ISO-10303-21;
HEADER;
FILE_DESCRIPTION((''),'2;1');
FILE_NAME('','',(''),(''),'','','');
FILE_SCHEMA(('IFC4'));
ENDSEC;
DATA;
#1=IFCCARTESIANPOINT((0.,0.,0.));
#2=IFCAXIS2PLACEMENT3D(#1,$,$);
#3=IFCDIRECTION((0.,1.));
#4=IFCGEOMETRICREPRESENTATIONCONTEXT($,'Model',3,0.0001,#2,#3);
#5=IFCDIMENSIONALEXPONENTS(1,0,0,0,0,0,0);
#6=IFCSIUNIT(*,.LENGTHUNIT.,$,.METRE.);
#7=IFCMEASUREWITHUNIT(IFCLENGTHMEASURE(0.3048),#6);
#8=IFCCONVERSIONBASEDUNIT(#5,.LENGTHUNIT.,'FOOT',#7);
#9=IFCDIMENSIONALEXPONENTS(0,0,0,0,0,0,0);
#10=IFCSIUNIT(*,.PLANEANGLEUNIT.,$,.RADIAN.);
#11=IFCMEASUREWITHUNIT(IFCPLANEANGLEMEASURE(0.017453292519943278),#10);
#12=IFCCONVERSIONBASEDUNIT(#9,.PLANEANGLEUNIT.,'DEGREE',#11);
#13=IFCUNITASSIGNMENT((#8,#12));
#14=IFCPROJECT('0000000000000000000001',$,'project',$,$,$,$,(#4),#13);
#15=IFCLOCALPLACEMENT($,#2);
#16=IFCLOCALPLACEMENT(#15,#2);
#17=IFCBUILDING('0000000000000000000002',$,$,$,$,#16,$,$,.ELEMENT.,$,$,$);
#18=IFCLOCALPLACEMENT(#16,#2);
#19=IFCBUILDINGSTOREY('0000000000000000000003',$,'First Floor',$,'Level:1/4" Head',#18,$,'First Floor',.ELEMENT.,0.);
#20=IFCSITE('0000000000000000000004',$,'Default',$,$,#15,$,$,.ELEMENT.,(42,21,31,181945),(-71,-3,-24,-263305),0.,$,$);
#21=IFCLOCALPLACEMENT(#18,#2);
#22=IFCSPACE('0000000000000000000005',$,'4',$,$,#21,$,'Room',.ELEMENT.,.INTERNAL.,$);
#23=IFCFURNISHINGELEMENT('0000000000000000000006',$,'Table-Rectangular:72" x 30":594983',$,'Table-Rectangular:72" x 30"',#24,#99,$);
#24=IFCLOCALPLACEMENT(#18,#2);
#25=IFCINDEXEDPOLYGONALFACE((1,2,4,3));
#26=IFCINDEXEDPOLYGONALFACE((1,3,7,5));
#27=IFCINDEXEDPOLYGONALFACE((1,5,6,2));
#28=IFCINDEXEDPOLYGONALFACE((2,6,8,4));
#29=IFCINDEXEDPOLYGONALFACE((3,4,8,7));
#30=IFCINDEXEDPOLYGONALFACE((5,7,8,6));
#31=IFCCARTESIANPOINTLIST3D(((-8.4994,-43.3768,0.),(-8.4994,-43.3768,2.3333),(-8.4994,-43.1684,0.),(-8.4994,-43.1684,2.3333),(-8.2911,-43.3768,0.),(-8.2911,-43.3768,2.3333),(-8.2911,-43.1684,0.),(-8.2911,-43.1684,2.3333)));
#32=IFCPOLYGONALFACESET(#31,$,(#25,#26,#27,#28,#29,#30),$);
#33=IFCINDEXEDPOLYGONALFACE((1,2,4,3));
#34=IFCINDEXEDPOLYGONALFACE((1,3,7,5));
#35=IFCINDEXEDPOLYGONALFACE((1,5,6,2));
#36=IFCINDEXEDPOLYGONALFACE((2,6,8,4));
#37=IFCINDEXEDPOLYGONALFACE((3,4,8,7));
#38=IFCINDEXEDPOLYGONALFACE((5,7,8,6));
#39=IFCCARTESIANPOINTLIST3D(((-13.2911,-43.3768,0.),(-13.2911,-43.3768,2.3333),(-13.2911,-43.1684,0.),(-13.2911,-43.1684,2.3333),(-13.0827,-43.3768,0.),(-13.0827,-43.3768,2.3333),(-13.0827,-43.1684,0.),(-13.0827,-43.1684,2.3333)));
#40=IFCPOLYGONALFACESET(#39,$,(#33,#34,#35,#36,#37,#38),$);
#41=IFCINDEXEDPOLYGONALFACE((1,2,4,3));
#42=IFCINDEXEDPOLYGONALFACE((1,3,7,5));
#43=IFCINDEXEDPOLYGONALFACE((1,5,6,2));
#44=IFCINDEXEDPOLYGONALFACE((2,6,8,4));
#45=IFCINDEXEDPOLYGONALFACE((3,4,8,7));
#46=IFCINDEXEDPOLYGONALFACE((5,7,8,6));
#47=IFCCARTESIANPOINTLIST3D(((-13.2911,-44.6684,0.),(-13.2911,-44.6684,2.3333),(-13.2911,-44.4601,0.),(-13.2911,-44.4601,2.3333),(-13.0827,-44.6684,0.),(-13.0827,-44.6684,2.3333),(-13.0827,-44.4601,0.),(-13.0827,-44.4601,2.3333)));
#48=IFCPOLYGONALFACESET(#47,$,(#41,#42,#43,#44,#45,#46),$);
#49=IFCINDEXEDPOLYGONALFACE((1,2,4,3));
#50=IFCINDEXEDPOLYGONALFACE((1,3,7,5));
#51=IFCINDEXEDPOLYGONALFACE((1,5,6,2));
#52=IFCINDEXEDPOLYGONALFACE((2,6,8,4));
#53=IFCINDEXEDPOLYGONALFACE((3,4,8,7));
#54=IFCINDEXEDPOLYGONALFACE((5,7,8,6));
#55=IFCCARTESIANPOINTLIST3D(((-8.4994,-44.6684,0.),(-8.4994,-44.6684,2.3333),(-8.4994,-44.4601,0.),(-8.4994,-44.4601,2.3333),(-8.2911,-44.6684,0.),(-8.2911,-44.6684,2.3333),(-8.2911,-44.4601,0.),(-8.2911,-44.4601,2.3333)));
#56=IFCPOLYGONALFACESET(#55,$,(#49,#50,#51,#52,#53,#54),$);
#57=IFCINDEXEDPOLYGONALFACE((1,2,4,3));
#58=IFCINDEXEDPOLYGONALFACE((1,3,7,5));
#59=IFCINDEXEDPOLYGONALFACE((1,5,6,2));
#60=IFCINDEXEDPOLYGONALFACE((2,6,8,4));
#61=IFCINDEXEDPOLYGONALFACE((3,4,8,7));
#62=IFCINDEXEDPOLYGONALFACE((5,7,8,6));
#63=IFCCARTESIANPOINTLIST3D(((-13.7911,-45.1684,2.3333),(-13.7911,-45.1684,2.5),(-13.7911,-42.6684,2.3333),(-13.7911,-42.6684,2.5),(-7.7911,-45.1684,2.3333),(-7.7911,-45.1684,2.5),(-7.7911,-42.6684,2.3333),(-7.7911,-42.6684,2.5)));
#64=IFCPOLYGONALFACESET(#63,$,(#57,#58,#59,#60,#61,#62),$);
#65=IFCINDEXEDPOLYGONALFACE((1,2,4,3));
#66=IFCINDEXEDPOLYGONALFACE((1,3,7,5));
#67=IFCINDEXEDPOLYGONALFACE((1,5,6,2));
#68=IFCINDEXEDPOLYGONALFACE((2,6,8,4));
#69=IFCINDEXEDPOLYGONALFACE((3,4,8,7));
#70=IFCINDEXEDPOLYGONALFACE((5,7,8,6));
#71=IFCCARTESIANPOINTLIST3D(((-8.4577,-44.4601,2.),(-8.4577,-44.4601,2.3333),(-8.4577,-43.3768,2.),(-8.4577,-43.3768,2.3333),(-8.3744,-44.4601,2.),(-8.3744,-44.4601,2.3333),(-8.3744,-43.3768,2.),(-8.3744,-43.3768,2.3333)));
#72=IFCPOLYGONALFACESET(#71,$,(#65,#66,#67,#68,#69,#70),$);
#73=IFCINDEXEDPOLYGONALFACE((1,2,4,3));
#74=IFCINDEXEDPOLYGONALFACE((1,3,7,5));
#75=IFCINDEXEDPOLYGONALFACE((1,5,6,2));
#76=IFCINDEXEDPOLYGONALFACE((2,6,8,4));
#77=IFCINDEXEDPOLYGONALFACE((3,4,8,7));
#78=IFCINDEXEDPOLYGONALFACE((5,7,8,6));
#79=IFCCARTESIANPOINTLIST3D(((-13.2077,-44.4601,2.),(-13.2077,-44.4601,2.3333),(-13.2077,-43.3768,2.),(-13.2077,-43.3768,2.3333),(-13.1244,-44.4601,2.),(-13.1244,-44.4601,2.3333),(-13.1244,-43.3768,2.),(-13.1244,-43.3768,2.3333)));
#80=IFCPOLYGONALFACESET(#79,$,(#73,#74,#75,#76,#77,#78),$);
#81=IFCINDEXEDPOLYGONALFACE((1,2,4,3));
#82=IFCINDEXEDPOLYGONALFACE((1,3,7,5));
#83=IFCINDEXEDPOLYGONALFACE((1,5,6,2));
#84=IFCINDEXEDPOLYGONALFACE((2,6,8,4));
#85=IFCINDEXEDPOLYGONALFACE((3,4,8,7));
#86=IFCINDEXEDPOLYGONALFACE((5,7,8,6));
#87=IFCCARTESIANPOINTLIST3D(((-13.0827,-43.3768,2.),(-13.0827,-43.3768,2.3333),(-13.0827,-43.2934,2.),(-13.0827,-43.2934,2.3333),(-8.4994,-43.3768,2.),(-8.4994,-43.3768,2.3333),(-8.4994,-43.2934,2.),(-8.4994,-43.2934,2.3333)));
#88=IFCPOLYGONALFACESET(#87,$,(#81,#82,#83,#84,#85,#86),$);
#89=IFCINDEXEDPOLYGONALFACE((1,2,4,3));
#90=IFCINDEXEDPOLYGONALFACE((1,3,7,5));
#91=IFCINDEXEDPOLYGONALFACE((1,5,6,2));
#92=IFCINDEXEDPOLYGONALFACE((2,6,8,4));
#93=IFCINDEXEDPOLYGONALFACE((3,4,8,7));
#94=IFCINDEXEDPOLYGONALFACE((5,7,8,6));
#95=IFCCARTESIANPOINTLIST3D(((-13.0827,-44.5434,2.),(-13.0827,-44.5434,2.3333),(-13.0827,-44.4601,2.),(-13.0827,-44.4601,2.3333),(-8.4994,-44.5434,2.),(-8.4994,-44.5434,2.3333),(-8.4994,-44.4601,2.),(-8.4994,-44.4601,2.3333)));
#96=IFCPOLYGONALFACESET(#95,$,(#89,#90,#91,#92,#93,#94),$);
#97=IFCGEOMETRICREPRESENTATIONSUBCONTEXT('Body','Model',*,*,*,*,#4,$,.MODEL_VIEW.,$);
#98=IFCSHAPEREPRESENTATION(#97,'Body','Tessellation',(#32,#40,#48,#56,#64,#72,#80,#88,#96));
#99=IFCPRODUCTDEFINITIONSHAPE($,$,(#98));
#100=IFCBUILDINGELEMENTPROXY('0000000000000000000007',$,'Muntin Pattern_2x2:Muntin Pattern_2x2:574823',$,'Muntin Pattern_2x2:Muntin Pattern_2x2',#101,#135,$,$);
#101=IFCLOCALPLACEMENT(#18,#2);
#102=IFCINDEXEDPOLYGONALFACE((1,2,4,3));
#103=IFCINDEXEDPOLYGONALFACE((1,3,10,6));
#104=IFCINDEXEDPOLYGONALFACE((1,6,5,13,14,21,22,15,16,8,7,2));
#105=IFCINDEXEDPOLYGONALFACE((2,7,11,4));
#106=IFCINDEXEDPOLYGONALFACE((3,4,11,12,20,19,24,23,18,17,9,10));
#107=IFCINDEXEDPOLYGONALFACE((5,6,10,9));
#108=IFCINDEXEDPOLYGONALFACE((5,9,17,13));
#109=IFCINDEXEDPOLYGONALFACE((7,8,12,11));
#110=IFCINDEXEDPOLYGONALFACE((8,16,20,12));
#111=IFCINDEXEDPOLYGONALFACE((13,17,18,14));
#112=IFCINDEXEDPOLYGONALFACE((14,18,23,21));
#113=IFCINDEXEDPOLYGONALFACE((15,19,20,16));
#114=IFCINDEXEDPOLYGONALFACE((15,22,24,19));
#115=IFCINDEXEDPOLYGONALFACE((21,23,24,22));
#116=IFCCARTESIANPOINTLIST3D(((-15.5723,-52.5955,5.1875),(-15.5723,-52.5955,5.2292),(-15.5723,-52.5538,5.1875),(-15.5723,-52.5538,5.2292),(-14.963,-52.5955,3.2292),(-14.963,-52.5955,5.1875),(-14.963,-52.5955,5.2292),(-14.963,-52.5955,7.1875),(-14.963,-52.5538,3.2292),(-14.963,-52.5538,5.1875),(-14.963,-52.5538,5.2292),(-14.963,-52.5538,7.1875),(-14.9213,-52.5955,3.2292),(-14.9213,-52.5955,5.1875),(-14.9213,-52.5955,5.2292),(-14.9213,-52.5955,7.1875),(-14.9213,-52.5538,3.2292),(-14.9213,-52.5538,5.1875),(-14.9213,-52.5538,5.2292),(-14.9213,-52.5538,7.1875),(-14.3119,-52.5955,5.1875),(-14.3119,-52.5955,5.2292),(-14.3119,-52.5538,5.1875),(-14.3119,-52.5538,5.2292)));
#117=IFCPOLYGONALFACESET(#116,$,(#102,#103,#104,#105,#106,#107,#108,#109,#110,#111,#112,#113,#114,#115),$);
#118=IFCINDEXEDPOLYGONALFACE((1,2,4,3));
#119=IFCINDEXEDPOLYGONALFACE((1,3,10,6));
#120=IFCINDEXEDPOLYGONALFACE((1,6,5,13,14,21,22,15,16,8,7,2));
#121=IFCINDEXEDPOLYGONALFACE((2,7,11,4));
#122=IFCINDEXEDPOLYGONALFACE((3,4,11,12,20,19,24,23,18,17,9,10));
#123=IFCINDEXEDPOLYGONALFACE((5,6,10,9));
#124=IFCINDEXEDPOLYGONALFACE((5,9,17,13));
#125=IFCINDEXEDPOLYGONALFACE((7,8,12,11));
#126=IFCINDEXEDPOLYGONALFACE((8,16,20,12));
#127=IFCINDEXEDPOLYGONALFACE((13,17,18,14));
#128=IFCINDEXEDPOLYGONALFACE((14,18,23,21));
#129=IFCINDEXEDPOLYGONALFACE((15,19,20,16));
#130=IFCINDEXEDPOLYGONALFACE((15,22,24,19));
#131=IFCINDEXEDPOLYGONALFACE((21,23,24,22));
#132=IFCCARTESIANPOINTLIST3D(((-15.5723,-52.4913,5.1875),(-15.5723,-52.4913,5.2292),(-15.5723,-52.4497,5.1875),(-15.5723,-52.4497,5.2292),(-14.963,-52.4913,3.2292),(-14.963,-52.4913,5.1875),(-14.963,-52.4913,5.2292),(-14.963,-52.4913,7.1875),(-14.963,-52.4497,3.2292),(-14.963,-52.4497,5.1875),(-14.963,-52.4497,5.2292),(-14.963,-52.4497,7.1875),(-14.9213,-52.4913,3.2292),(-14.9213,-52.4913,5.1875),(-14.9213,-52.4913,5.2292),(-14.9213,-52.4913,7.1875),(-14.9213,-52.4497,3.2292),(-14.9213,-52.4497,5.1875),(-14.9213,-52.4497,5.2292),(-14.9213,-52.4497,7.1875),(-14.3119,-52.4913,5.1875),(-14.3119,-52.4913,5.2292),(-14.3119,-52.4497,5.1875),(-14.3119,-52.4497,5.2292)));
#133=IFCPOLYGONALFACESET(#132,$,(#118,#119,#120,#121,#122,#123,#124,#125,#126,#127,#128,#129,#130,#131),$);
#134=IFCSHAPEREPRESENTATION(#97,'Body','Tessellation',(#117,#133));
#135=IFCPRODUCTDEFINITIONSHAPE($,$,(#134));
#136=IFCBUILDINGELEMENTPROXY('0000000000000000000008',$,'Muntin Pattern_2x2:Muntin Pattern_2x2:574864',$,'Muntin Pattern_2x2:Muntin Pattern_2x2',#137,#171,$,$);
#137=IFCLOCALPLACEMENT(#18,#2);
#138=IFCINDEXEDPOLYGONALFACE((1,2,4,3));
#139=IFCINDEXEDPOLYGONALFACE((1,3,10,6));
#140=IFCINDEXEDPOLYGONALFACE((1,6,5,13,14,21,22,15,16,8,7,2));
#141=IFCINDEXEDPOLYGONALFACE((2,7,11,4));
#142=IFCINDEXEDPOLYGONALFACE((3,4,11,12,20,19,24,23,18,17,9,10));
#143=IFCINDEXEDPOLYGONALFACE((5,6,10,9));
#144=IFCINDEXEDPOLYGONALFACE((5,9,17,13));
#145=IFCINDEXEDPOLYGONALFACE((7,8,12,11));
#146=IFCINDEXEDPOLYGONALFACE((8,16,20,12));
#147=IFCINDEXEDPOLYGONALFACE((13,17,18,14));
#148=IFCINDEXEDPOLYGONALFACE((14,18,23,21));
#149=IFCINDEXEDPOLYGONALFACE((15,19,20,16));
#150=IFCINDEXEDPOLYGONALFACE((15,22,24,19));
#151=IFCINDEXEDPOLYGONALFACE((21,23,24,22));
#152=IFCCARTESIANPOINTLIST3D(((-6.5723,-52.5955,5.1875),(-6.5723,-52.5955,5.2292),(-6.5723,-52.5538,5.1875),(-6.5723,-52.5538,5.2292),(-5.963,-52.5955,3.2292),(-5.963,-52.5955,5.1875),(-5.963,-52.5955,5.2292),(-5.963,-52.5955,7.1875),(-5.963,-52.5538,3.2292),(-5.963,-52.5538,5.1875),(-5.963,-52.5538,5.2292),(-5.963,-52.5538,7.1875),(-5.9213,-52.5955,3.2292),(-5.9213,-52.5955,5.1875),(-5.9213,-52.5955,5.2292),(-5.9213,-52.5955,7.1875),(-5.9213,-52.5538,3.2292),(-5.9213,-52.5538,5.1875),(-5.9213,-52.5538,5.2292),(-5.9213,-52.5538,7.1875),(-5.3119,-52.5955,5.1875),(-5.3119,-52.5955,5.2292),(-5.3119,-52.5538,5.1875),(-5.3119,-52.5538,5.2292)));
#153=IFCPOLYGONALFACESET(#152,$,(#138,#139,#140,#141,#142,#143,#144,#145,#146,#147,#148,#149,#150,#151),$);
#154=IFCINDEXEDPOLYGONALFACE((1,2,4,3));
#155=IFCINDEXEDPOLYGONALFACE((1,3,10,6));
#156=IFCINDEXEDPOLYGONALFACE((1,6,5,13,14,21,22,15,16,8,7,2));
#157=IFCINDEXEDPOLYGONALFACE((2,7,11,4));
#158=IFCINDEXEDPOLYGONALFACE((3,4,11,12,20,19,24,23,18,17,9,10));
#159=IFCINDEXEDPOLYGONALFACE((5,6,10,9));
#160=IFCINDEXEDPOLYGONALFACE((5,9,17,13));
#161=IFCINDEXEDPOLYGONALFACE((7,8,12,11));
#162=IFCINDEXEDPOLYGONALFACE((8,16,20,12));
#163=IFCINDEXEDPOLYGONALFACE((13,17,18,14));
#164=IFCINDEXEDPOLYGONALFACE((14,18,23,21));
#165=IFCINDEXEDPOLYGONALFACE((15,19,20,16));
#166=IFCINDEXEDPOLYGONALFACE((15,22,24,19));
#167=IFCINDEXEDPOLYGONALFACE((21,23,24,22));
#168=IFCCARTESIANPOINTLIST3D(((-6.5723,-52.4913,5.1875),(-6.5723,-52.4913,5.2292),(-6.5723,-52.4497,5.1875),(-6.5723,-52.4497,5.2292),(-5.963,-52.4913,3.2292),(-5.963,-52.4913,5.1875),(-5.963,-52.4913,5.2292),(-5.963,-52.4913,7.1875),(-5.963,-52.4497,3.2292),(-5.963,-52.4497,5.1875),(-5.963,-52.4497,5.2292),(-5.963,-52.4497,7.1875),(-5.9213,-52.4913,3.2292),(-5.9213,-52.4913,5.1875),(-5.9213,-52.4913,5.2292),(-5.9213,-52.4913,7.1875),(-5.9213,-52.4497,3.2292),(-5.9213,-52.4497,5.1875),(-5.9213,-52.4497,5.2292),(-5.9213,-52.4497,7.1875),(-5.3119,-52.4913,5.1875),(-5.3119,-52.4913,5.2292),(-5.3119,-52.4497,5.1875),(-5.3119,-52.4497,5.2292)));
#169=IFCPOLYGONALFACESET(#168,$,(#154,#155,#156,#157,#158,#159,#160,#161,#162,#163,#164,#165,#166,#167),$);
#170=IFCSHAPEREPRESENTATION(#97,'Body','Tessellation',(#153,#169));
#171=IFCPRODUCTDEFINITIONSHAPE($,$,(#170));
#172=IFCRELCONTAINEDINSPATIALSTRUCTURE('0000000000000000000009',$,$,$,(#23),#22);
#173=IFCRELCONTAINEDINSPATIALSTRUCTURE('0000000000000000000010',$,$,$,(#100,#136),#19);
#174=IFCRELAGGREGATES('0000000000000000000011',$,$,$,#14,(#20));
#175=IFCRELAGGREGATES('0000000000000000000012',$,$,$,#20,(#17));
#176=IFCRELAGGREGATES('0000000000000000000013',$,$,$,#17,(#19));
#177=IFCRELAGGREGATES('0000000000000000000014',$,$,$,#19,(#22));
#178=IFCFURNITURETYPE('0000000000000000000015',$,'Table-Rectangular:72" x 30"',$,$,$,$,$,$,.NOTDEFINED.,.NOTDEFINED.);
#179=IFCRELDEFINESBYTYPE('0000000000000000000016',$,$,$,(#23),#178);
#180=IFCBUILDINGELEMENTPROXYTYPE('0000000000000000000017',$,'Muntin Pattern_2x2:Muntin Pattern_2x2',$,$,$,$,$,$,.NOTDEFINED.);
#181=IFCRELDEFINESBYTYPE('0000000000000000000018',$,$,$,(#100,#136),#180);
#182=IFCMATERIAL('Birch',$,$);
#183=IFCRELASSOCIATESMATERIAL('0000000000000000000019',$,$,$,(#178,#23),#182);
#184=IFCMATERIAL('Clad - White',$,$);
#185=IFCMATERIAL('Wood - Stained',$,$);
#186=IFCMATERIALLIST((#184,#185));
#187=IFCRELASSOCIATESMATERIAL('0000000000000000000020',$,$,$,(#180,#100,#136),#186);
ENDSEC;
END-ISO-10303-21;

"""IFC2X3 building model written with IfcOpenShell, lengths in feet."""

from ifc_helpers import new_model, entity, si_unit, converted_unit, direction, frame, frame_2d, origin, origin_2d_with_axis, place, context, subcontext, project, spatial, polyline, rectangle, outline, extrude, source, transform, mapped, material, material_list, type_object, type_shapes, element, save


model = new_model("IFC2X3")

# Units and contexts
model_context = context("Model", 3, precision=0.0001, world=origin(), true_north=direction((0.0, 1.0)))
body_context = subcontext(model_context, "Body", "Model", "MODEL_VIEW")
ifc_project = project(units=[converted_unit("LENGTHUNIT", "FOOT", entity("IfcLengthMeasure", 0.3048), si_unit("LENGTHUNIT", "METRE"), dimensions=[1, 0, 0, 0, 0, 0, 0]), converted_unit("PLANEANGLEUNIT", "DEGREE", entity("IfcPlaneAngleMeasure", 0.017453292519943278), si_unit("PLANEANGLEUNIT", "RADIAN"), dimensions=[0, 0, 0, 0, 0, 0, 0])], contexts=[model_context])

# Site, building, storey
site_placement = place(None, origin())
site = spatial("IfcSite", under=ifc_project, at=site_placement, Name="Default", CompositionType="ELEMENT", RefLatitude=(42, 21, 31, 181945), RefLongitude=(-71, -3, -24, -263305), RefElevation=0.0)
building_placement = place(site_placement, origin())
building = spatial("IfcBuilding", under=site, at=building_placement, CompositionType="ELEMENT")
storey_placement = place(building_placement, origin())
storey = spatial("IfcBuildingStorey", under=building, at=storey_placement, Name="First Floor", ObjectType="Level:1/4\" Head", LongName="First Floor", CompositionType="ELEMENT", Elevation=0.0)

# Shared definitions
space_1_placement = place(storey_placement, origin())
space_1 = spatial("IfcSpace", under=storey, at=space_1_placement, Name="4", LongName="Room", CompositionType="ELEMENT", InteriorOrExteriorSpace="INTERNAL")

# Furnishing element
ifc_material_1 = material(Name="Birch")
furniture_type_1 = type_object("IfcFurnitureType", Name="Table-Rectangular:72\" x 30\"", AssemblyPlace="NOTDEFINED", material=ifc_material_1)
shared_shape_1 = source(origin(), body_context, "Body", "SweptSolid", [
    extrude(rectangle(XDim=0.2083, YDim=0.2083, at=origin_2d_with_axis()), frame((2.3958, 0.6458, 0.0), z_axis=(0.0, 0.0, 1.0), x_axis=(0.0, -1.0, 0.0)), (0.0, 0.0, 1.0), 2.3333),
    extrude(rectangle(XDim=0.2083, YDim=0.2083, at=origin_2d_with_axis()), frame((-2.3958, 0.6458, 0.0), z_axis=(0.0, 0.0, 1.0), x_axis=(-1.0, 0.0, 0.0)), (0.0, 0.0, 1.0), 2.3333),
    extrude(rectangle(XDim=0.2083, YDim=0.2083, at=origin_2d_with_axis()), frame((-2.3958, -0.6458, 0.0), z_axis=(0.0, 0.0, 1.0), x_axis=(0.0, 1.0, 0.0)), (0.0, 0.0, 1.0), 2.3333),
    extrude(rectangle(XDim=0.2083, YDim=0.2083, at=origin_2d_with_axis()), frame((2.3958, -0.6458, 0.0)), (0.0, 0.0, 1.0), 2.3333),
    extrude(rectangle(XDim=6.0, YDim=2.5, at=origin_2d_with_axis()), frame((0.0, 0.0, 2.3333), z_axis=(0.0, 0.0, 1.0), x_axis=(-1.0, 0.0, 0.0)), (0.0, 0.0, 1.0), 0.1667),
    extrude(rectangle(XDim=0.0833, YDim=1.0833, at=origin_2d_with_axis()), frame((2.375, 0.0, 2.0)), (0.0, 0.0, 1.0), 0.3333),
    extrude(rectangle(XDim=1.0833, YDim=0.0833, at=origin_2d_with_axis()), frame((-2.375, 0.0, 2.0), z_axis=(0.0, 0.0, 1.0), x_axis=(0.0, 1.0, 0.0)), (0.0, 0.0, 1.0), 0.3333),
    extrude(rectangle(XDim=4.5833, YDim=0.0833, at=frame_2d((0.0, 0.0), x_axis=(1.0, 0.0))), frame((0.0, 0.5833, 2.0), z_axis=(0.0, 0.0, 1.0), x_axis=(-1.0, 0.0, 0.0)), (0.0, 0.0, 1.0), 0.3333),
    extrude(rectangle(XDim=0.0833, YDim=4.5833, at=origin_2d_with_axis()), frame((0.0, -0.5833, 2.0), z_axis=(0.0, 0.0, 1.0), x_axis=(0.0, 1.0, 0.0)), (0.0, 0.0, 1.0), 0.3333),
])
type_shapes(furniture_type_1, [shared_shape_1])
furnishing_placement = place(space_1_placement, frame((-10.7911, -43.9184, 0.0)))
element("IfcFurnishingElement", 1, at=furnishing_placement, inside=space_1, type_object=furniture_type_1, material=ifc_material_1, Name="Table-Rectangular:72\" x 30\":594983", ObjectType="Table-Rectangular:72\" x 30\"", context=body_context, shape_type="MappedRepresentation", body=[
    mapped(shared_shape_1, transform((0.0, 0.0, 0.0), scale=1.0)),
])

# Building element proxies
ifc_material_2 = material(Name="Clad - White")
ifc_material_3 = material(Name="Wood - Stained")
ifc_material_list_1 = material_list([ifc_material_2, ifc_material_3])
building_element_proxy_type_1 = type_object("IfcBuildingElementProxyType", Name="Muntin Pattern_2x2:Muntin Pattern_2x2", PredefinedType="NOTDEFINED", material=ifc_material_list_1)
shared_shape_2 = source(origin(), body_context, "Body", "SweptSolid", [
    extrude(outline(polyline([(0.0208, -0.0208), (1.9792, -0.0208), (1.9792, 0.0208), (0.0208, 0.0208), (0.0208, 0.6302), (-0.0208, 0.6302), (-0.0208, 0.0208), (-1.9792, 0.0208), (-1.9792, -0.0208), (-0.0208, -0.0208), (-0.0208, -0.6302), (0.0208, -0.6302), (0.0208, -0.0208)])), frame((0.0, 0.0313, 1.9792), z_axis=(0.0, 1.0, 0.0), x_axis=(0.0, 0.0, 1.0)), (0.0, 0.0, 1.0), 0.0417),
    extrude(outline(polyline([(0.0208, -0.0208), (1.9792, -0.0208), (1.9792, 0.0208), (0.0208, 0.0208), (0.0208, 0.6302), (-0.0208, 0.6302), (-0.0208, 0.0208), (-1.9792, 0.0208), (-1.9792, -0.0208), (-0.0208, -0.0208), (-0.0208, -0.6302), (0.0208, -0.6302), (0.0208, -0.0208)])), frame((0.0, -0.0729, 1.9792), z_axis=(0.0, 1.0, 0.0), x_axis=(0.0, 0.0, 1.0)), (0.0, 0.0, 1.0), 0.0417),
])
type_shapes(building_element_proxy_type_1, [shared_shape_2])
for number, where, z_axis, x_axis, name in (
    (2, (-14.9421, -52.5226, 3.2292), (0.0, 0.0, 1.0), (-1.0, 0.0, 0.0), "Muntin Pattern_2x2:Muntin Pattern_2x2:574823"),
    (3, (-5.9421, -52.5226, 3.2292), (0.0, 0.0, 1.0), (-1.0, 0.0, 0.0), "Muntin Pattern_2x2:Muntin Pattern_2x2:574864"),
):
    element("IfcBuildingElementProxy", number, at=place(storey_placement, frame(where, z_axis=z_axis, x_axis=x_axis)), inside=storey, type_object=building_element_proxy_type_1, material=ifc_material_list_1, Name=name, ObjectType="Muntin Pattern_2x2:Muntin Pattern_2x2", context=body_context, shape_type="MappedRepresentation", body=[
        mapped(shared_shape_2, transform((0.0, 0.0, 0.0), scale=1.0)),
    ])

save(model, "model.ifc")
